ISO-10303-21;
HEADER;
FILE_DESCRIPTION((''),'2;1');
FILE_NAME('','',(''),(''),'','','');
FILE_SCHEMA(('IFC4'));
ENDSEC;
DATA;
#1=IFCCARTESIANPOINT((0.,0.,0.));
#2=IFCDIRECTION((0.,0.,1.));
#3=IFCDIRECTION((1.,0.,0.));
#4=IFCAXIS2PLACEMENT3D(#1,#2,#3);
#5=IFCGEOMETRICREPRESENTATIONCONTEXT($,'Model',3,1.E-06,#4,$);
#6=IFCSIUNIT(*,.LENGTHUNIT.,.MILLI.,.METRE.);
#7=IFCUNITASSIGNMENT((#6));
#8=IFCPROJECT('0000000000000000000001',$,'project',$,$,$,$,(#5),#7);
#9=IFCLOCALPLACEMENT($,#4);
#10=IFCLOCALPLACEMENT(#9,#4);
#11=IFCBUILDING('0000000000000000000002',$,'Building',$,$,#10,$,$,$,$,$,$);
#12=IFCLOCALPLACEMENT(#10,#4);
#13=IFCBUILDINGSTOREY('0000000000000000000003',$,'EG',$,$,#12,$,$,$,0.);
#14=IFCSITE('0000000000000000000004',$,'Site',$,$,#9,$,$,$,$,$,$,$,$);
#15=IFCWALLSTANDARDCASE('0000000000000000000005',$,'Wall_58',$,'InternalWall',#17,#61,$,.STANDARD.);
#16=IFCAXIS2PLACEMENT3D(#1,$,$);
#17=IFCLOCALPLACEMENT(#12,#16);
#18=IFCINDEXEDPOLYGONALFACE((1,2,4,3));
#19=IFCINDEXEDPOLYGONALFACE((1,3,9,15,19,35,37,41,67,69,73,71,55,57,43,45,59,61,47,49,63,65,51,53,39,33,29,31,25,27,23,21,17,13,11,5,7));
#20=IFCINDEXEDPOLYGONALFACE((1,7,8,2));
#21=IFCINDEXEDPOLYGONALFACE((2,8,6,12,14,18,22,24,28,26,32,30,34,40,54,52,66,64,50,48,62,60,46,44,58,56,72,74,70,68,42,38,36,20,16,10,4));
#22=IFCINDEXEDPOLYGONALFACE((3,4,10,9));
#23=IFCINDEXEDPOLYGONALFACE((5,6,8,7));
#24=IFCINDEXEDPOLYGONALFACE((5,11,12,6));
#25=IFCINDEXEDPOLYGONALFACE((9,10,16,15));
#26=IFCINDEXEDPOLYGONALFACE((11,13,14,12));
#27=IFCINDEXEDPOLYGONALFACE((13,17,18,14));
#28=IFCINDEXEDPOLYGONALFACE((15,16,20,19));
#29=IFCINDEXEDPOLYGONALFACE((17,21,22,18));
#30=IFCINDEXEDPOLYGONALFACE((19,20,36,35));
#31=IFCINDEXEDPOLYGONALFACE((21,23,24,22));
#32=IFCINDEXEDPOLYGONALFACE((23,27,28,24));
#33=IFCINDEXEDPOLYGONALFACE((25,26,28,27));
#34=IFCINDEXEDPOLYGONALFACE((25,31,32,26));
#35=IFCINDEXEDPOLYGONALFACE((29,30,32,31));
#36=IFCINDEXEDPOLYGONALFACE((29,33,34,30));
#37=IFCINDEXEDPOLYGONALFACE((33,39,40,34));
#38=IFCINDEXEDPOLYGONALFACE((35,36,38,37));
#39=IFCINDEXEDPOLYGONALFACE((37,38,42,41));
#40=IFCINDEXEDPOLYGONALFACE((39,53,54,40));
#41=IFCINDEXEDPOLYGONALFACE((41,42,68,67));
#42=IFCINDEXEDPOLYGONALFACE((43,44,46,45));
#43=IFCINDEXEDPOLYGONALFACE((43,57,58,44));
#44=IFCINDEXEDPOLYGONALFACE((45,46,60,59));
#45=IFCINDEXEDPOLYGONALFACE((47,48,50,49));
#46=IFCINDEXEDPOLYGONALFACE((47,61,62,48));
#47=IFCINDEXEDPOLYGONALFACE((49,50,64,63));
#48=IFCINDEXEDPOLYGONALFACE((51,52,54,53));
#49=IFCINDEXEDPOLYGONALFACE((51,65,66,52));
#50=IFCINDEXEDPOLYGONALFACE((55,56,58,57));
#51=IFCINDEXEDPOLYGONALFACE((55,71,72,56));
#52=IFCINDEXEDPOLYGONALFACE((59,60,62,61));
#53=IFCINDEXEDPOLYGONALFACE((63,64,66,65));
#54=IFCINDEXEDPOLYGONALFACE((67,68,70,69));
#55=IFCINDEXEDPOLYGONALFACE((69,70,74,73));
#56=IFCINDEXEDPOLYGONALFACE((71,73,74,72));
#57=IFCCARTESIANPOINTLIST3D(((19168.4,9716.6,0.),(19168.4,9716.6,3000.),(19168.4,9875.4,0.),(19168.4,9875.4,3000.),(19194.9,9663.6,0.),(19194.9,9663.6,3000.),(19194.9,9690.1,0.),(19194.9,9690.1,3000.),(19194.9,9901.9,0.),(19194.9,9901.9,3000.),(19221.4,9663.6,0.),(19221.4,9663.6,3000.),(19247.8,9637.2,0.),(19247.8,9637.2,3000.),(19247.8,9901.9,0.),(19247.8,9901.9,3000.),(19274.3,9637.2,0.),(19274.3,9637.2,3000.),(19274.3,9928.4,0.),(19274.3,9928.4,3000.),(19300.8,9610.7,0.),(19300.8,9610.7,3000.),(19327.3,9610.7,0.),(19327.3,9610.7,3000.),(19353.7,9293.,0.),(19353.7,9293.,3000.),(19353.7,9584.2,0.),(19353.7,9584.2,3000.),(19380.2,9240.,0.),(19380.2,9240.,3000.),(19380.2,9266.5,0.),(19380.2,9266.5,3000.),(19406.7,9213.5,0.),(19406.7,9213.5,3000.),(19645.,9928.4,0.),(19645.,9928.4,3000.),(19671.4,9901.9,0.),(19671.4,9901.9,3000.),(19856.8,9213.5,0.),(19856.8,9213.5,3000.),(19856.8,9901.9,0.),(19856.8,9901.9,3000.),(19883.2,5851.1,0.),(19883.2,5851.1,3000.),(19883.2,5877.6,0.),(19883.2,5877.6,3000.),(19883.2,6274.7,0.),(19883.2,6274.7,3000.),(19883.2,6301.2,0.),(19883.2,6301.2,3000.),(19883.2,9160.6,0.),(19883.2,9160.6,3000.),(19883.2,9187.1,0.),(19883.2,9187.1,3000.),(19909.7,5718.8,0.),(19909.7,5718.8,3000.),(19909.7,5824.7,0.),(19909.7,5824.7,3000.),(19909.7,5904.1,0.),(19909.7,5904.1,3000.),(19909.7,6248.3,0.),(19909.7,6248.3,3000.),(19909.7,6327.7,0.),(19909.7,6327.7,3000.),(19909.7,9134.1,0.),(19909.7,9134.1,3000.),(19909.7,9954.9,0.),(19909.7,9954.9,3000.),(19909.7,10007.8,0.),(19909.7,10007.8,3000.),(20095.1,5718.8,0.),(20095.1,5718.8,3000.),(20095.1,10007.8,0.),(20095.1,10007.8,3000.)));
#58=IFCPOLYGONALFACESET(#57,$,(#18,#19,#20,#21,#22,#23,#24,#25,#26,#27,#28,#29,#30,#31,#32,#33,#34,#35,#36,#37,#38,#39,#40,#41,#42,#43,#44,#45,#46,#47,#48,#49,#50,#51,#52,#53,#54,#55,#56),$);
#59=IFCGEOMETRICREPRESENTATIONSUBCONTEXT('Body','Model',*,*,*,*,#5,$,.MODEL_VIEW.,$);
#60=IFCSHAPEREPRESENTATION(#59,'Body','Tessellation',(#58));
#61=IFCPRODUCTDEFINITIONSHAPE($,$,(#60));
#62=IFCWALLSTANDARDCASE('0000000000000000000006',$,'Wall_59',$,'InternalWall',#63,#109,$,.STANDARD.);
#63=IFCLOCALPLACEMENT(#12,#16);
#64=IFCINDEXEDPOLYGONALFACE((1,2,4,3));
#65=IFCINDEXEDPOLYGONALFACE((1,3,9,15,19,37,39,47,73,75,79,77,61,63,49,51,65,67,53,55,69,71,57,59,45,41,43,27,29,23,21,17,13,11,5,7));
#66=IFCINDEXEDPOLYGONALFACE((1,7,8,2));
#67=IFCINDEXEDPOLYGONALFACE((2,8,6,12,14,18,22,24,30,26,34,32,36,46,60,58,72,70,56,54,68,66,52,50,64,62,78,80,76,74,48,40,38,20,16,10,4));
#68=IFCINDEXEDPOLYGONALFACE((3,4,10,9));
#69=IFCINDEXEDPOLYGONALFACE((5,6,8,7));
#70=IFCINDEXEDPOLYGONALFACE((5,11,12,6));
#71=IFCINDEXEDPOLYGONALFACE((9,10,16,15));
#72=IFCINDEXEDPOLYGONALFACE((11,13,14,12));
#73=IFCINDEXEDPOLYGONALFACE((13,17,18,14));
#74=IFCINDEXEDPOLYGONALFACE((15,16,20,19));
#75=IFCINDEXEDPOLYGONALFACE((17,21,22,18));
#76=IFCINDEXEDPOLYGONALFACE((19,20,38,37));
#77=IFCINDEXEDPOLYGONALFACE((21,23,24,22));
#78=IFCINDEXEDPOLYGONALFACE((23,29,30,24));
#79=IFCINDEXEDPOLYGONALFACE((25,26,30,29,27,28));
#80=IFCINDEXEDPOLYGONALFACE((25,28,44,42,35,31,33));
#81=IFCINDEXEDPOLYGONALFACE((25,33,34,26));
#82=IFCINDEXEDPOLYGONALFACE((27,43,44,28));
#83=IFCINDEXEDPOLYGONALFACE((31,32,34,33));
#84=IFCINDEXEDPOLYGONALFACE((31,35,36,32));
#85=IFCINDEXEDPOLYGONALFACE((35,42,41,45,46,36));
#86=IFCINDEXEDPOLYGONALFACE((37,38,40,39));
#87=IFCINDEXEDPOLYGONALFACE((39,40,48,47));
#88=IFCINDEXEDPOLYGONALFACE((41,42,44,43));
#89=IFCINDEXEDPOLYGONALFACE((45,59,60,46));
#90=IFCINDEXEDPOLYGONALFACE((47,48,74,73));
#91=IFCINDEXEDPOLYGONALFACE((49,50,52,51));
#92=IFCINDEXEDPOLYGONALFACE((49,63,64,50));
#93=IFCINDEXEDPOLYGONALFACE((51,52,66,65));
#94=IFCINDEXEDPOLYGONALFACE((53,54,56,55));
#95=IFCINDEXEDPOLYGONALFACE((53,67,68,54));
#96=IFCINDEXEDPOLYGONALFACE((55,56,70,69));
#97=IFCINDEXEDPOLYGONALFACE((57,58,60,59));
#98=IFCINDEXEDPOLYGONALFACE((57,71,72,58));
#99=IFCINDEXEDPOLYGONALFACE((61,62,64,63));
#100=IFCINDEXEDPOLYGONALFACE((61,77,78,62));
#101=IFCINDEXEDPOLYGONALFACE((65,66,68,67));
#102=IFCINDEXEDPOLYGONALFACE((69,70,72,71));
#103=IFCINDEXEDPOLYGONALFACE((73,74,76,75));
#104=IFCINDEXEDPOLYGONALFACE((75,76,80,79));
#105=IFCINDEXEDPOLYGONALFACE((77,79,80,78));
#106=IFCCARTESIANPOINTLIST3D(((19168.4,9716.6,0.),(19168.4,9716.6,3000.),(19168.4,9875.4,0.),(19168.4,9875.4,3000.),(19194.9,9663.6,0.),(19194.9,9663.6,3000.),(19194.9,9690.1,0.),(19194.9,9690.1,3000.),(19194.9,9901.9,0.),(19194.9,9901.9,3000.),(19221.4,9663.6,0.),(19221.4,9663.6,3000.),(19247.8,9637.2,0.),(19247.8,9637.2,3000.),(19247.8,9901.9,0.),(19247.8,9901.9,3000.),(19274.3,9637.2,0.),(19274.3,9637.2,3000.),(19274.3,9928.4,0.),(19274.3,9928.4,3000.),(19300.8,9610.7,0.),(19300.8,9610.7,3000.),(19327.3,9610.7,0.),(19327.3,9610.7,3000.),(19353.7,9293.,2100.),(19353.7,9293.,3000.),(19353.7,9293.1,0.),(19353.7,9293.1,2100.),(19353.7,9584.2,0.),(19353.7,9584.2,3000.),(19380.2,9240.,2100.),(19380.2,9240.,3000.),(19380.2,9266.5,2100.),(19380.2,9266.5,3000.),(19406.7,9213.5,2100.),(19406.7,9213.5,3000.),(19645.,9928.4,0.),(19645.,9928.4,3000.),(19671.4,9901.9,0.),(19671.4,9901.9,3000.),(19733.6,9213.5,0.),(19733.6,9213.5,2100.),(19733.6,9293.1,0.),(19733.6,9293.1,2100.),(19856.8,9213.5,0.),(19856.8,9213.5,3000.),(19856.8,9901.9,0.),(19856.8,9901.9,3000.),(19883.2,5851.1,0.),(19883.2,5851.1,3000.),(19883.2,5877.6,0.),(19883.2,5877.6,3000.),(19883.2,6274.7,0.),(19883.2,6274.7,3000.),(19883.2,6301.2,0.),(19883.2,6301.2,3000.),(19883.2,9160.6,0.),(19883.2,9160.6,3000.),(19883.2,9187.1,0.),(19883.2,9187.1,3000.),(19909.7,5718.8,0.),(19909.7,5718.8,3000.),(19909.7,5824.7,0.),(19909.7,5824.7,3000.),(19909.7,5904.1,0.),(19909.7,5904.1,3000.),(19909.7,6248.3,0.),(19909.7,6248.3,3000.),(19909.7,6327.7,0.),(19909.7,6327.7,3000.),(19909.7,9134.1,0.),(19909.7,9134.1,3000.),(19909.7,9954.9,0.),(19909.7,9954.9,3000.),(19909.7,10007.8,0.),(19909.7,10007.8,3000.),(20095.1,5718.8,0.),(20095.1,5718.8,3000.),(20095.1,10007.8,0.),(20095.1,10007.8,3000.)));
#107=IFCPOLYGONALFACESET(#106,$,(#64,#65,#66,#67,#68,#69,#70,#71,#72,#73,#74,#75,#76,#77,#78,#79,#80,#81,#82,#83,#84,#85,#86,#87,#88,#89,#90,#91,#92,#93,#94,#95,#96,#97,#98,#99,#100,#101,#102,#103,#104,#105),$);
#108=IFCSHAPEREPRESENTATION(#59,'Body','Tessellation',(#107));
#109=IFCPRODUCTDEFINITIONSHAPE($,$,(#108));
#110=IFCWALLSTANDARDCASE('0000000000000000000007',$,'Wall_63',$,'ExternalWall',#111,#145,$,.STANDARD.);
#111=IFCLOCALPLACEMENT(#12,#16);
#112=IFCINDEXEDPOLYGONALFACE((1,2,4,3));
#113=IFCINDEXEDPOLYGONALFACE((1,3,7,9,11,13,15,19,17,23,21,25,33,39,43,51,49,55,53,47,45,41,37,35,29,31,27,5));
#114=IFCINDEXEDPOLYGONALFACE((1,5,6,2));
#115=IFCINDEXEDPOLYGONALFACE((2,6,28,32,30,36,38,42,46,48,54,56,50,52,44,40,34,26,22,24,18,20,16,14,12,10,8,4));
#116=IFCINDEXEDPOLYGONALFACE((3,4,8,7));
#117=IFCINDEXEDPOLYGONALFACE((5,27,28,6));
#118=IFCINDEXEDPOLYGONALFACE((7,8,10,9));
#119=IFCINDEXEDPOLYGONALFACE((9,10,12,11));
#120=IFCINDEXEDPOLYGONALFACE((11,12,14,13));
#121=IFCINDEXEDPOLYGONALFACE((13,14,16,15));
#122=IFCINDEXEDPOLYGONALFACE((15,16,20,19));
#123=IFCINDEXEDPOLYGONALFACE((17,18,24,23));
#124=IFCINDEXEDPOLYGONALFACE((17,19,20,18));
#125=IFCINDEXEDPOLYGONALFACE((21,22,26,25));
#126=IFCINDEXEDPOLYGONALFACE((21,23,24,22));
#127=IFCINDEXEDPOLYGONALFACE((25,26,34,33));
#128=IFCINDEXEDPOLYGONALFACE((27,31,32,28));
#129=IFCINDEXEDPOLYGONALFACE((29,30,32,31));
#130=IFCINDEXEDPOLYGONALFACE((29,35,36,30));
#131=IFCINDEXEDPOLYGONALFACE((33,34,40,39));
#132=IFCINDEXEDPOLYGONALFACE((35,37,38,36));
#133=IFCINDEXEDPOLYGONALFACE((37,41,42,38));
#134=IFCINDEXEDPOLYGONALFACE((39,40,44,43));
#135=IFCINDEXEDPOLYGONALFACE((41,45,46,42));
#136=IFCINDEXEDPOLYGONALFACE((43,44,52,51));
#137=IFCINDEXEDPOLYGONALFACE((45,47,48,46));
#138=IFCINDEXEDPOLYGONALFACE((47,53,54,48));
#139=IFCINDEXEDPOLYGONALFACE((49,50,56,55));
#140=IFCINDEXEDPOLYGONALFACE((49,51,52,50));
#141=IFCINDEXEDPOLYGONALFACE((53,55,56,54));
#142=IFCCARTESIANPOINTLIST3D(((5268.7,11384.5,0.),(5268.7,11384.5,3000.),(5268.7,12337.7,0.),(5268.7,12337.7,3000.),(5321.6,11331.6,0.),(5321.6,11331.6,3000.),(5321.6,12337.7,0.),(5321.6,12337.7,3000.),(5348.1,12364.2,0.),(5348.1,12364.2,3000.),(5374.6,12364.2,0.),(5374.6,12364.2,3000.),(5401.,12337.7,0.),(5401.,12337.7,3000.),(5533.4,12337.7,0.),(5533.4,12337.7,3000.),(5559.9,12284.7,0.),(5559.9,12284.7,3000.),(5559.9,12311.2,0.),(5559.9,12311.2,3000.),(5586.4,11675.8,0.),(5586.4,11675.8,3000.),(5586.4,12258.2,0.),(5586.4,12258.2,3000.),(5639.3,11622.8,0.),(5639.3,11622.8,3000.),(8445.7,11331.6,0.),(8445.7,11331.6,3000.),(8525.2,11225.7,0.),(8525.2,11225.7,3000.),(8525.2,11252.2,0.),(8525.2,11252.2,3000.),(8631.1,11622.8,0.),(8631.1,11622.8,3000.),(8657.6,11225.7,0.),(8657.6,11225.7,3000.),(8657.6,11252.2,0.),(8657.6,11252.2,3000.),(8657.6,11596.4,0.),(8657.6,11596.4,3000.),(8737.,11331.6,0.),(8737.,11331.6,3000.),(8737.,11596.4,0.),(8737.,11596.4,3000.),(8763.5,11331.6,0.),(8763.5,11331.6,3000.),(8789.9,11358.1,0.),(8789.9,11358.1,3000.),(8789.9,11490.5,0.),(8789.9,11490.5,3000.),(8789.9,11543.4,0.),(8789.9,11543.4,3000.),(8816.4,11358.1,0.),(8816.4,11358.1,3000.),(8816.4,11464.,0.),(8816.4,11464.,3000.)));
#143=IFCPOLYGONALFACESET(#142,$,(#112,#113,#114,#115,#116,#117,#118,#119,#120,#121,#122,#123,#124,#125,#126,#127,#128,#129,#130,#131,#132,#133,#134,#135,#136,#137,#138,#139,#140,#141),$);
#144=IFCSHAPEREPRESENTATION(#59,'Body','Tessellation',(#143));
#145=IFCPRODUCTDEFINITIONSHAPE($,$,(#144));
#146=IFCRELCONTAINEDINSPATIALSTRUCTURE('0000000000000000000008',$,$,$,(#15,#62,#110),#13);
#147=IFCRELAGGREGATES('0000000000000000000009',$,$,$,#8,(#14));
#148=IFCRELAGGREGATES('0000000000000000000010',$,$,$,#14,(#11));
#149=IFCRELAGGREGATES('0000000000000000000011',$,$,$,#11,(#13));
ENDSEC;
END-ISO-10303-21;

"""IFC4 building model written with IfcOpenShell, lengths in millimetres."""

from ifc_helpers import new_model, si_unit, frame, origin_with_axes, place, context, subcontext, project, spatial, polyline, rectangle, outline, extrude, element, save


model = new_model("IFC4")

# Units and contexts
model_context = context("Model", 3, precision=1e-06, world=origin_with_axes())
body_context = subcontext(model_context, "Body", "Model", "MODEL_VIEW")
ifc_project = project(units=[si_unit("LENGTHUNIT", "METRE", prefix="MILLI")], contexts=[model_context])

# Site, building, storey
site_placement = place(None, origin_with_axes())
site = spatial("IfcSite", under=ifc_project, at=site_placement, Name="Site")
building_placement = place(site_placement, origin_with_axes())
building = spatial("IfcBuilding", under=site, at=building_placement, Name="Building")
storey_placement = place(building_placement, origin_with_axes())
storey = spatial("IfcBuildingStorey", under=building, at=storey_placement, Name="EG", Elevation=0.0)

# Wall
wall_1_placement = place(storey_placement, origin_with_axes())
element("IfcWallStandardCase", 1, at=wall_1_placement, inside=storey, Name="Wall_58", ObjectType="InternalWall", PredefinedType="STANDARD", context=body_context, shape_type="SweptSolid", body=[
    extrude(outline(polyline([(19909.7, 5718.8, 0.0), (19909.7, 5824.7, 0.0), (19883.2, 5851.1, 0.0), (19883.2, 5877.6, 0.0), (19909.7, 5904.1, 0.0), (19909.7, 6248.3, 0.0), (19883.2, 6274.7, 0.0), (19883.2, 6301.2, 0.0), (19909.7, 6327.7, 0.0), (19909.7, 9134.1, 0.0), (19883.2, 9160.6, 0.0), (19883.2, 9187.1, 0.0), (19856.8, 9213.5, 0.0), (19406.7, 9213.5, 0.0), (19380.2, 9240.0, 0.0), (19380.2, 9266.5, 0.0), (19353.7, 9293.0, 0.0), (19353.7, 9584.2, 0.0), (19327.3, 9610.7, 0.0), (19300.8, 9610.7, 0.0), (19274.3, 9637.2, 0.0), (19247.8, 9637.2, 0.0), (19221.4, 9663.6, 0.0), (19194.9, 9663.6, 0.0), (19194.9, 9690.1, 0.0), (19168.4, 9716.6, 0.0), (19168.4, 9875.4, 0.0), (19194.9, 9901.9, 0.0), (19247.8, 9901.9, 0.0), (19274.3, 9928.4, 0.0), (19645.0, 9928.4, 0.0), (19671.4, 9901.9, 0.0), (19856.8, 9901.9, 0.0), (19909.7, 9954.9, 0.0), (19909.7, 10007.8, 0.0), (20095.1, 10007.8, 0.0), (20095.1, 5718.8, 0.0), (19909.7, 5718.8, 0.0)])), origin_with_axes(), (0.0, 0.0, 1.0), 3000.0),
])

# Wall, opening
wall_2_placement = place(storey_placement, origin_with_axes())
wall_2 = element("IfcWallStandardCase", 2, at=wall_2_placement, inside=storey, Name="Wall_59", ObjectType="InternalWall", PredefinedType="STANDARD", context=body_context, shape_type="SweptSolid", body=[
    extrude(outline(polyline([(19909.7, 5718.8, 0.0), (19909.7, 5824.7, 0.0), (19883.2, 5851.1, 0.0), (19883.2, 5877.6, 0.0), (19909.7, 5904.1, 0.0), (19909.7, 6248.3, 0.0), (19883.2, 6274.7, 0.0), (19883.2, 6301.2, 0.0), (19909.7, 6327.7, 0.0), (19909.7, 9134.1, 0.0), (19883.2, 9160.6, 0.0), (19883.2, 9187.1, 0.0), (19856.8, 9213.5, 0.0), (19406.7, 9213.5, 0.0), (19380.2, 9240.0, 0.0), (19380.2, 9266.5, 0.0), (19353.7, 9293.0, 0.0), (19353.7, 9584.2, 0.0), (19327.3, 9610.7, 0.0), (19300.8, 9610.7, 0.0), (19274.3, 9637.2, 0.0), (19247.8, 9637.2, 0.0), (19221.4, 9663.6, 0.0), (19194.9, 9663.6, 0.0), (19194.9, 9690.1, 0.0), (19168.4, 9716.6, 0.0), (19168.4, 9875.4, 0.0), (19194.9, 9901.9, 0.0), (19247.8, 9901.9, 0.0), (19274.3, 9928.4, 0.0), (19645.0, 9928.4, 0.0), (19671.4, 9901.9, 0.0), (19856.8, 9901.9, 0.0), (19909.7, 9954.9, 0.0), (19909.7, 10007.8, 0.0), (20095.1, 10007.8, 0.0), (20095.1, 5718.8, 0.0), (19909.7, 5718.8, 0.0)])), origin_with_axes(), (0.0, 0.0, 1.0), 3000.0),
])
opening_1_placement = place(wall_2_placement, origin_with_axes())
element("IfcOpeningElement", 3, at=opening_1_placement, inside=storey, cuts=wall_2, context=body_context, shape_type="SweptSolid", body=[
    extrude(rectangle(XDim=1048.4, YDim=400.0), frame((19209.4, 9093.1, 0.0), z_axis=(0.0, 0.0, 1.0), x_axis=(1.0, 0.0, 0.0)), (0.0, 0.0, 1.0), 2100.0),
])

# Wall
wall_3_placement = place(storey_placement, origin_with_axes())
element("IfcWallStandardCase", 4, at=wall_3_placement, inside=storey, Name="Wall_63", ObjectType="ExternalWall", PredefinedType="STANDARD", context=body_context, shape_type="SweptSolid", body=[
    extrude(outline(polyline([(8525.2, 11225.7, 0.0), (8525.2, 11252.2, 0.0), (8445.7, 11331.6, 0.0), (5321.6, 11331.6, 0.0), (5268.7, 11384.5, 0.0), (5268.7, 12337.7, 0.0), (5321.6, 12337.7, 0.0), (5348.1, 12364.2, 0.0), (5374.6, 12364.2, 0.0), (5401.0, 12337.7, 0.0), (5533.4, 12337.7, 0.0), (5559.9, 12311.2, 0.0), (5559.9, 12284.7, 0.0), (5586.4, 12258.2, 0.0), (5586.4, 11675.8, 0.0), (5639.3, 11622.8, 0.0), (8631.1, 11622.8, 0.0), (8657.6, 11596.4, 0.0), (8737.0, 11596.4, 0.0), (8789.9, 11543.4, 0.0), (8789.9, 11490.5, 0.0), (8816.4, 11464.0, 0.0), (8816.4, 11358.1, 0.0), (8789.9, 11358.1, 0.0), (8763.5, 11331.6, 0.0), (8737.0, 11331.6, 0.0), (8657.6, 11252.2, 0.0), (8657.6, 11225.7, 0.0), (8525.2, 11225.7, 0.0)])), origin_with_axes(), (0.0, 0.0, 1.0), 3000.0),
])

save(model, "model.ifc")
